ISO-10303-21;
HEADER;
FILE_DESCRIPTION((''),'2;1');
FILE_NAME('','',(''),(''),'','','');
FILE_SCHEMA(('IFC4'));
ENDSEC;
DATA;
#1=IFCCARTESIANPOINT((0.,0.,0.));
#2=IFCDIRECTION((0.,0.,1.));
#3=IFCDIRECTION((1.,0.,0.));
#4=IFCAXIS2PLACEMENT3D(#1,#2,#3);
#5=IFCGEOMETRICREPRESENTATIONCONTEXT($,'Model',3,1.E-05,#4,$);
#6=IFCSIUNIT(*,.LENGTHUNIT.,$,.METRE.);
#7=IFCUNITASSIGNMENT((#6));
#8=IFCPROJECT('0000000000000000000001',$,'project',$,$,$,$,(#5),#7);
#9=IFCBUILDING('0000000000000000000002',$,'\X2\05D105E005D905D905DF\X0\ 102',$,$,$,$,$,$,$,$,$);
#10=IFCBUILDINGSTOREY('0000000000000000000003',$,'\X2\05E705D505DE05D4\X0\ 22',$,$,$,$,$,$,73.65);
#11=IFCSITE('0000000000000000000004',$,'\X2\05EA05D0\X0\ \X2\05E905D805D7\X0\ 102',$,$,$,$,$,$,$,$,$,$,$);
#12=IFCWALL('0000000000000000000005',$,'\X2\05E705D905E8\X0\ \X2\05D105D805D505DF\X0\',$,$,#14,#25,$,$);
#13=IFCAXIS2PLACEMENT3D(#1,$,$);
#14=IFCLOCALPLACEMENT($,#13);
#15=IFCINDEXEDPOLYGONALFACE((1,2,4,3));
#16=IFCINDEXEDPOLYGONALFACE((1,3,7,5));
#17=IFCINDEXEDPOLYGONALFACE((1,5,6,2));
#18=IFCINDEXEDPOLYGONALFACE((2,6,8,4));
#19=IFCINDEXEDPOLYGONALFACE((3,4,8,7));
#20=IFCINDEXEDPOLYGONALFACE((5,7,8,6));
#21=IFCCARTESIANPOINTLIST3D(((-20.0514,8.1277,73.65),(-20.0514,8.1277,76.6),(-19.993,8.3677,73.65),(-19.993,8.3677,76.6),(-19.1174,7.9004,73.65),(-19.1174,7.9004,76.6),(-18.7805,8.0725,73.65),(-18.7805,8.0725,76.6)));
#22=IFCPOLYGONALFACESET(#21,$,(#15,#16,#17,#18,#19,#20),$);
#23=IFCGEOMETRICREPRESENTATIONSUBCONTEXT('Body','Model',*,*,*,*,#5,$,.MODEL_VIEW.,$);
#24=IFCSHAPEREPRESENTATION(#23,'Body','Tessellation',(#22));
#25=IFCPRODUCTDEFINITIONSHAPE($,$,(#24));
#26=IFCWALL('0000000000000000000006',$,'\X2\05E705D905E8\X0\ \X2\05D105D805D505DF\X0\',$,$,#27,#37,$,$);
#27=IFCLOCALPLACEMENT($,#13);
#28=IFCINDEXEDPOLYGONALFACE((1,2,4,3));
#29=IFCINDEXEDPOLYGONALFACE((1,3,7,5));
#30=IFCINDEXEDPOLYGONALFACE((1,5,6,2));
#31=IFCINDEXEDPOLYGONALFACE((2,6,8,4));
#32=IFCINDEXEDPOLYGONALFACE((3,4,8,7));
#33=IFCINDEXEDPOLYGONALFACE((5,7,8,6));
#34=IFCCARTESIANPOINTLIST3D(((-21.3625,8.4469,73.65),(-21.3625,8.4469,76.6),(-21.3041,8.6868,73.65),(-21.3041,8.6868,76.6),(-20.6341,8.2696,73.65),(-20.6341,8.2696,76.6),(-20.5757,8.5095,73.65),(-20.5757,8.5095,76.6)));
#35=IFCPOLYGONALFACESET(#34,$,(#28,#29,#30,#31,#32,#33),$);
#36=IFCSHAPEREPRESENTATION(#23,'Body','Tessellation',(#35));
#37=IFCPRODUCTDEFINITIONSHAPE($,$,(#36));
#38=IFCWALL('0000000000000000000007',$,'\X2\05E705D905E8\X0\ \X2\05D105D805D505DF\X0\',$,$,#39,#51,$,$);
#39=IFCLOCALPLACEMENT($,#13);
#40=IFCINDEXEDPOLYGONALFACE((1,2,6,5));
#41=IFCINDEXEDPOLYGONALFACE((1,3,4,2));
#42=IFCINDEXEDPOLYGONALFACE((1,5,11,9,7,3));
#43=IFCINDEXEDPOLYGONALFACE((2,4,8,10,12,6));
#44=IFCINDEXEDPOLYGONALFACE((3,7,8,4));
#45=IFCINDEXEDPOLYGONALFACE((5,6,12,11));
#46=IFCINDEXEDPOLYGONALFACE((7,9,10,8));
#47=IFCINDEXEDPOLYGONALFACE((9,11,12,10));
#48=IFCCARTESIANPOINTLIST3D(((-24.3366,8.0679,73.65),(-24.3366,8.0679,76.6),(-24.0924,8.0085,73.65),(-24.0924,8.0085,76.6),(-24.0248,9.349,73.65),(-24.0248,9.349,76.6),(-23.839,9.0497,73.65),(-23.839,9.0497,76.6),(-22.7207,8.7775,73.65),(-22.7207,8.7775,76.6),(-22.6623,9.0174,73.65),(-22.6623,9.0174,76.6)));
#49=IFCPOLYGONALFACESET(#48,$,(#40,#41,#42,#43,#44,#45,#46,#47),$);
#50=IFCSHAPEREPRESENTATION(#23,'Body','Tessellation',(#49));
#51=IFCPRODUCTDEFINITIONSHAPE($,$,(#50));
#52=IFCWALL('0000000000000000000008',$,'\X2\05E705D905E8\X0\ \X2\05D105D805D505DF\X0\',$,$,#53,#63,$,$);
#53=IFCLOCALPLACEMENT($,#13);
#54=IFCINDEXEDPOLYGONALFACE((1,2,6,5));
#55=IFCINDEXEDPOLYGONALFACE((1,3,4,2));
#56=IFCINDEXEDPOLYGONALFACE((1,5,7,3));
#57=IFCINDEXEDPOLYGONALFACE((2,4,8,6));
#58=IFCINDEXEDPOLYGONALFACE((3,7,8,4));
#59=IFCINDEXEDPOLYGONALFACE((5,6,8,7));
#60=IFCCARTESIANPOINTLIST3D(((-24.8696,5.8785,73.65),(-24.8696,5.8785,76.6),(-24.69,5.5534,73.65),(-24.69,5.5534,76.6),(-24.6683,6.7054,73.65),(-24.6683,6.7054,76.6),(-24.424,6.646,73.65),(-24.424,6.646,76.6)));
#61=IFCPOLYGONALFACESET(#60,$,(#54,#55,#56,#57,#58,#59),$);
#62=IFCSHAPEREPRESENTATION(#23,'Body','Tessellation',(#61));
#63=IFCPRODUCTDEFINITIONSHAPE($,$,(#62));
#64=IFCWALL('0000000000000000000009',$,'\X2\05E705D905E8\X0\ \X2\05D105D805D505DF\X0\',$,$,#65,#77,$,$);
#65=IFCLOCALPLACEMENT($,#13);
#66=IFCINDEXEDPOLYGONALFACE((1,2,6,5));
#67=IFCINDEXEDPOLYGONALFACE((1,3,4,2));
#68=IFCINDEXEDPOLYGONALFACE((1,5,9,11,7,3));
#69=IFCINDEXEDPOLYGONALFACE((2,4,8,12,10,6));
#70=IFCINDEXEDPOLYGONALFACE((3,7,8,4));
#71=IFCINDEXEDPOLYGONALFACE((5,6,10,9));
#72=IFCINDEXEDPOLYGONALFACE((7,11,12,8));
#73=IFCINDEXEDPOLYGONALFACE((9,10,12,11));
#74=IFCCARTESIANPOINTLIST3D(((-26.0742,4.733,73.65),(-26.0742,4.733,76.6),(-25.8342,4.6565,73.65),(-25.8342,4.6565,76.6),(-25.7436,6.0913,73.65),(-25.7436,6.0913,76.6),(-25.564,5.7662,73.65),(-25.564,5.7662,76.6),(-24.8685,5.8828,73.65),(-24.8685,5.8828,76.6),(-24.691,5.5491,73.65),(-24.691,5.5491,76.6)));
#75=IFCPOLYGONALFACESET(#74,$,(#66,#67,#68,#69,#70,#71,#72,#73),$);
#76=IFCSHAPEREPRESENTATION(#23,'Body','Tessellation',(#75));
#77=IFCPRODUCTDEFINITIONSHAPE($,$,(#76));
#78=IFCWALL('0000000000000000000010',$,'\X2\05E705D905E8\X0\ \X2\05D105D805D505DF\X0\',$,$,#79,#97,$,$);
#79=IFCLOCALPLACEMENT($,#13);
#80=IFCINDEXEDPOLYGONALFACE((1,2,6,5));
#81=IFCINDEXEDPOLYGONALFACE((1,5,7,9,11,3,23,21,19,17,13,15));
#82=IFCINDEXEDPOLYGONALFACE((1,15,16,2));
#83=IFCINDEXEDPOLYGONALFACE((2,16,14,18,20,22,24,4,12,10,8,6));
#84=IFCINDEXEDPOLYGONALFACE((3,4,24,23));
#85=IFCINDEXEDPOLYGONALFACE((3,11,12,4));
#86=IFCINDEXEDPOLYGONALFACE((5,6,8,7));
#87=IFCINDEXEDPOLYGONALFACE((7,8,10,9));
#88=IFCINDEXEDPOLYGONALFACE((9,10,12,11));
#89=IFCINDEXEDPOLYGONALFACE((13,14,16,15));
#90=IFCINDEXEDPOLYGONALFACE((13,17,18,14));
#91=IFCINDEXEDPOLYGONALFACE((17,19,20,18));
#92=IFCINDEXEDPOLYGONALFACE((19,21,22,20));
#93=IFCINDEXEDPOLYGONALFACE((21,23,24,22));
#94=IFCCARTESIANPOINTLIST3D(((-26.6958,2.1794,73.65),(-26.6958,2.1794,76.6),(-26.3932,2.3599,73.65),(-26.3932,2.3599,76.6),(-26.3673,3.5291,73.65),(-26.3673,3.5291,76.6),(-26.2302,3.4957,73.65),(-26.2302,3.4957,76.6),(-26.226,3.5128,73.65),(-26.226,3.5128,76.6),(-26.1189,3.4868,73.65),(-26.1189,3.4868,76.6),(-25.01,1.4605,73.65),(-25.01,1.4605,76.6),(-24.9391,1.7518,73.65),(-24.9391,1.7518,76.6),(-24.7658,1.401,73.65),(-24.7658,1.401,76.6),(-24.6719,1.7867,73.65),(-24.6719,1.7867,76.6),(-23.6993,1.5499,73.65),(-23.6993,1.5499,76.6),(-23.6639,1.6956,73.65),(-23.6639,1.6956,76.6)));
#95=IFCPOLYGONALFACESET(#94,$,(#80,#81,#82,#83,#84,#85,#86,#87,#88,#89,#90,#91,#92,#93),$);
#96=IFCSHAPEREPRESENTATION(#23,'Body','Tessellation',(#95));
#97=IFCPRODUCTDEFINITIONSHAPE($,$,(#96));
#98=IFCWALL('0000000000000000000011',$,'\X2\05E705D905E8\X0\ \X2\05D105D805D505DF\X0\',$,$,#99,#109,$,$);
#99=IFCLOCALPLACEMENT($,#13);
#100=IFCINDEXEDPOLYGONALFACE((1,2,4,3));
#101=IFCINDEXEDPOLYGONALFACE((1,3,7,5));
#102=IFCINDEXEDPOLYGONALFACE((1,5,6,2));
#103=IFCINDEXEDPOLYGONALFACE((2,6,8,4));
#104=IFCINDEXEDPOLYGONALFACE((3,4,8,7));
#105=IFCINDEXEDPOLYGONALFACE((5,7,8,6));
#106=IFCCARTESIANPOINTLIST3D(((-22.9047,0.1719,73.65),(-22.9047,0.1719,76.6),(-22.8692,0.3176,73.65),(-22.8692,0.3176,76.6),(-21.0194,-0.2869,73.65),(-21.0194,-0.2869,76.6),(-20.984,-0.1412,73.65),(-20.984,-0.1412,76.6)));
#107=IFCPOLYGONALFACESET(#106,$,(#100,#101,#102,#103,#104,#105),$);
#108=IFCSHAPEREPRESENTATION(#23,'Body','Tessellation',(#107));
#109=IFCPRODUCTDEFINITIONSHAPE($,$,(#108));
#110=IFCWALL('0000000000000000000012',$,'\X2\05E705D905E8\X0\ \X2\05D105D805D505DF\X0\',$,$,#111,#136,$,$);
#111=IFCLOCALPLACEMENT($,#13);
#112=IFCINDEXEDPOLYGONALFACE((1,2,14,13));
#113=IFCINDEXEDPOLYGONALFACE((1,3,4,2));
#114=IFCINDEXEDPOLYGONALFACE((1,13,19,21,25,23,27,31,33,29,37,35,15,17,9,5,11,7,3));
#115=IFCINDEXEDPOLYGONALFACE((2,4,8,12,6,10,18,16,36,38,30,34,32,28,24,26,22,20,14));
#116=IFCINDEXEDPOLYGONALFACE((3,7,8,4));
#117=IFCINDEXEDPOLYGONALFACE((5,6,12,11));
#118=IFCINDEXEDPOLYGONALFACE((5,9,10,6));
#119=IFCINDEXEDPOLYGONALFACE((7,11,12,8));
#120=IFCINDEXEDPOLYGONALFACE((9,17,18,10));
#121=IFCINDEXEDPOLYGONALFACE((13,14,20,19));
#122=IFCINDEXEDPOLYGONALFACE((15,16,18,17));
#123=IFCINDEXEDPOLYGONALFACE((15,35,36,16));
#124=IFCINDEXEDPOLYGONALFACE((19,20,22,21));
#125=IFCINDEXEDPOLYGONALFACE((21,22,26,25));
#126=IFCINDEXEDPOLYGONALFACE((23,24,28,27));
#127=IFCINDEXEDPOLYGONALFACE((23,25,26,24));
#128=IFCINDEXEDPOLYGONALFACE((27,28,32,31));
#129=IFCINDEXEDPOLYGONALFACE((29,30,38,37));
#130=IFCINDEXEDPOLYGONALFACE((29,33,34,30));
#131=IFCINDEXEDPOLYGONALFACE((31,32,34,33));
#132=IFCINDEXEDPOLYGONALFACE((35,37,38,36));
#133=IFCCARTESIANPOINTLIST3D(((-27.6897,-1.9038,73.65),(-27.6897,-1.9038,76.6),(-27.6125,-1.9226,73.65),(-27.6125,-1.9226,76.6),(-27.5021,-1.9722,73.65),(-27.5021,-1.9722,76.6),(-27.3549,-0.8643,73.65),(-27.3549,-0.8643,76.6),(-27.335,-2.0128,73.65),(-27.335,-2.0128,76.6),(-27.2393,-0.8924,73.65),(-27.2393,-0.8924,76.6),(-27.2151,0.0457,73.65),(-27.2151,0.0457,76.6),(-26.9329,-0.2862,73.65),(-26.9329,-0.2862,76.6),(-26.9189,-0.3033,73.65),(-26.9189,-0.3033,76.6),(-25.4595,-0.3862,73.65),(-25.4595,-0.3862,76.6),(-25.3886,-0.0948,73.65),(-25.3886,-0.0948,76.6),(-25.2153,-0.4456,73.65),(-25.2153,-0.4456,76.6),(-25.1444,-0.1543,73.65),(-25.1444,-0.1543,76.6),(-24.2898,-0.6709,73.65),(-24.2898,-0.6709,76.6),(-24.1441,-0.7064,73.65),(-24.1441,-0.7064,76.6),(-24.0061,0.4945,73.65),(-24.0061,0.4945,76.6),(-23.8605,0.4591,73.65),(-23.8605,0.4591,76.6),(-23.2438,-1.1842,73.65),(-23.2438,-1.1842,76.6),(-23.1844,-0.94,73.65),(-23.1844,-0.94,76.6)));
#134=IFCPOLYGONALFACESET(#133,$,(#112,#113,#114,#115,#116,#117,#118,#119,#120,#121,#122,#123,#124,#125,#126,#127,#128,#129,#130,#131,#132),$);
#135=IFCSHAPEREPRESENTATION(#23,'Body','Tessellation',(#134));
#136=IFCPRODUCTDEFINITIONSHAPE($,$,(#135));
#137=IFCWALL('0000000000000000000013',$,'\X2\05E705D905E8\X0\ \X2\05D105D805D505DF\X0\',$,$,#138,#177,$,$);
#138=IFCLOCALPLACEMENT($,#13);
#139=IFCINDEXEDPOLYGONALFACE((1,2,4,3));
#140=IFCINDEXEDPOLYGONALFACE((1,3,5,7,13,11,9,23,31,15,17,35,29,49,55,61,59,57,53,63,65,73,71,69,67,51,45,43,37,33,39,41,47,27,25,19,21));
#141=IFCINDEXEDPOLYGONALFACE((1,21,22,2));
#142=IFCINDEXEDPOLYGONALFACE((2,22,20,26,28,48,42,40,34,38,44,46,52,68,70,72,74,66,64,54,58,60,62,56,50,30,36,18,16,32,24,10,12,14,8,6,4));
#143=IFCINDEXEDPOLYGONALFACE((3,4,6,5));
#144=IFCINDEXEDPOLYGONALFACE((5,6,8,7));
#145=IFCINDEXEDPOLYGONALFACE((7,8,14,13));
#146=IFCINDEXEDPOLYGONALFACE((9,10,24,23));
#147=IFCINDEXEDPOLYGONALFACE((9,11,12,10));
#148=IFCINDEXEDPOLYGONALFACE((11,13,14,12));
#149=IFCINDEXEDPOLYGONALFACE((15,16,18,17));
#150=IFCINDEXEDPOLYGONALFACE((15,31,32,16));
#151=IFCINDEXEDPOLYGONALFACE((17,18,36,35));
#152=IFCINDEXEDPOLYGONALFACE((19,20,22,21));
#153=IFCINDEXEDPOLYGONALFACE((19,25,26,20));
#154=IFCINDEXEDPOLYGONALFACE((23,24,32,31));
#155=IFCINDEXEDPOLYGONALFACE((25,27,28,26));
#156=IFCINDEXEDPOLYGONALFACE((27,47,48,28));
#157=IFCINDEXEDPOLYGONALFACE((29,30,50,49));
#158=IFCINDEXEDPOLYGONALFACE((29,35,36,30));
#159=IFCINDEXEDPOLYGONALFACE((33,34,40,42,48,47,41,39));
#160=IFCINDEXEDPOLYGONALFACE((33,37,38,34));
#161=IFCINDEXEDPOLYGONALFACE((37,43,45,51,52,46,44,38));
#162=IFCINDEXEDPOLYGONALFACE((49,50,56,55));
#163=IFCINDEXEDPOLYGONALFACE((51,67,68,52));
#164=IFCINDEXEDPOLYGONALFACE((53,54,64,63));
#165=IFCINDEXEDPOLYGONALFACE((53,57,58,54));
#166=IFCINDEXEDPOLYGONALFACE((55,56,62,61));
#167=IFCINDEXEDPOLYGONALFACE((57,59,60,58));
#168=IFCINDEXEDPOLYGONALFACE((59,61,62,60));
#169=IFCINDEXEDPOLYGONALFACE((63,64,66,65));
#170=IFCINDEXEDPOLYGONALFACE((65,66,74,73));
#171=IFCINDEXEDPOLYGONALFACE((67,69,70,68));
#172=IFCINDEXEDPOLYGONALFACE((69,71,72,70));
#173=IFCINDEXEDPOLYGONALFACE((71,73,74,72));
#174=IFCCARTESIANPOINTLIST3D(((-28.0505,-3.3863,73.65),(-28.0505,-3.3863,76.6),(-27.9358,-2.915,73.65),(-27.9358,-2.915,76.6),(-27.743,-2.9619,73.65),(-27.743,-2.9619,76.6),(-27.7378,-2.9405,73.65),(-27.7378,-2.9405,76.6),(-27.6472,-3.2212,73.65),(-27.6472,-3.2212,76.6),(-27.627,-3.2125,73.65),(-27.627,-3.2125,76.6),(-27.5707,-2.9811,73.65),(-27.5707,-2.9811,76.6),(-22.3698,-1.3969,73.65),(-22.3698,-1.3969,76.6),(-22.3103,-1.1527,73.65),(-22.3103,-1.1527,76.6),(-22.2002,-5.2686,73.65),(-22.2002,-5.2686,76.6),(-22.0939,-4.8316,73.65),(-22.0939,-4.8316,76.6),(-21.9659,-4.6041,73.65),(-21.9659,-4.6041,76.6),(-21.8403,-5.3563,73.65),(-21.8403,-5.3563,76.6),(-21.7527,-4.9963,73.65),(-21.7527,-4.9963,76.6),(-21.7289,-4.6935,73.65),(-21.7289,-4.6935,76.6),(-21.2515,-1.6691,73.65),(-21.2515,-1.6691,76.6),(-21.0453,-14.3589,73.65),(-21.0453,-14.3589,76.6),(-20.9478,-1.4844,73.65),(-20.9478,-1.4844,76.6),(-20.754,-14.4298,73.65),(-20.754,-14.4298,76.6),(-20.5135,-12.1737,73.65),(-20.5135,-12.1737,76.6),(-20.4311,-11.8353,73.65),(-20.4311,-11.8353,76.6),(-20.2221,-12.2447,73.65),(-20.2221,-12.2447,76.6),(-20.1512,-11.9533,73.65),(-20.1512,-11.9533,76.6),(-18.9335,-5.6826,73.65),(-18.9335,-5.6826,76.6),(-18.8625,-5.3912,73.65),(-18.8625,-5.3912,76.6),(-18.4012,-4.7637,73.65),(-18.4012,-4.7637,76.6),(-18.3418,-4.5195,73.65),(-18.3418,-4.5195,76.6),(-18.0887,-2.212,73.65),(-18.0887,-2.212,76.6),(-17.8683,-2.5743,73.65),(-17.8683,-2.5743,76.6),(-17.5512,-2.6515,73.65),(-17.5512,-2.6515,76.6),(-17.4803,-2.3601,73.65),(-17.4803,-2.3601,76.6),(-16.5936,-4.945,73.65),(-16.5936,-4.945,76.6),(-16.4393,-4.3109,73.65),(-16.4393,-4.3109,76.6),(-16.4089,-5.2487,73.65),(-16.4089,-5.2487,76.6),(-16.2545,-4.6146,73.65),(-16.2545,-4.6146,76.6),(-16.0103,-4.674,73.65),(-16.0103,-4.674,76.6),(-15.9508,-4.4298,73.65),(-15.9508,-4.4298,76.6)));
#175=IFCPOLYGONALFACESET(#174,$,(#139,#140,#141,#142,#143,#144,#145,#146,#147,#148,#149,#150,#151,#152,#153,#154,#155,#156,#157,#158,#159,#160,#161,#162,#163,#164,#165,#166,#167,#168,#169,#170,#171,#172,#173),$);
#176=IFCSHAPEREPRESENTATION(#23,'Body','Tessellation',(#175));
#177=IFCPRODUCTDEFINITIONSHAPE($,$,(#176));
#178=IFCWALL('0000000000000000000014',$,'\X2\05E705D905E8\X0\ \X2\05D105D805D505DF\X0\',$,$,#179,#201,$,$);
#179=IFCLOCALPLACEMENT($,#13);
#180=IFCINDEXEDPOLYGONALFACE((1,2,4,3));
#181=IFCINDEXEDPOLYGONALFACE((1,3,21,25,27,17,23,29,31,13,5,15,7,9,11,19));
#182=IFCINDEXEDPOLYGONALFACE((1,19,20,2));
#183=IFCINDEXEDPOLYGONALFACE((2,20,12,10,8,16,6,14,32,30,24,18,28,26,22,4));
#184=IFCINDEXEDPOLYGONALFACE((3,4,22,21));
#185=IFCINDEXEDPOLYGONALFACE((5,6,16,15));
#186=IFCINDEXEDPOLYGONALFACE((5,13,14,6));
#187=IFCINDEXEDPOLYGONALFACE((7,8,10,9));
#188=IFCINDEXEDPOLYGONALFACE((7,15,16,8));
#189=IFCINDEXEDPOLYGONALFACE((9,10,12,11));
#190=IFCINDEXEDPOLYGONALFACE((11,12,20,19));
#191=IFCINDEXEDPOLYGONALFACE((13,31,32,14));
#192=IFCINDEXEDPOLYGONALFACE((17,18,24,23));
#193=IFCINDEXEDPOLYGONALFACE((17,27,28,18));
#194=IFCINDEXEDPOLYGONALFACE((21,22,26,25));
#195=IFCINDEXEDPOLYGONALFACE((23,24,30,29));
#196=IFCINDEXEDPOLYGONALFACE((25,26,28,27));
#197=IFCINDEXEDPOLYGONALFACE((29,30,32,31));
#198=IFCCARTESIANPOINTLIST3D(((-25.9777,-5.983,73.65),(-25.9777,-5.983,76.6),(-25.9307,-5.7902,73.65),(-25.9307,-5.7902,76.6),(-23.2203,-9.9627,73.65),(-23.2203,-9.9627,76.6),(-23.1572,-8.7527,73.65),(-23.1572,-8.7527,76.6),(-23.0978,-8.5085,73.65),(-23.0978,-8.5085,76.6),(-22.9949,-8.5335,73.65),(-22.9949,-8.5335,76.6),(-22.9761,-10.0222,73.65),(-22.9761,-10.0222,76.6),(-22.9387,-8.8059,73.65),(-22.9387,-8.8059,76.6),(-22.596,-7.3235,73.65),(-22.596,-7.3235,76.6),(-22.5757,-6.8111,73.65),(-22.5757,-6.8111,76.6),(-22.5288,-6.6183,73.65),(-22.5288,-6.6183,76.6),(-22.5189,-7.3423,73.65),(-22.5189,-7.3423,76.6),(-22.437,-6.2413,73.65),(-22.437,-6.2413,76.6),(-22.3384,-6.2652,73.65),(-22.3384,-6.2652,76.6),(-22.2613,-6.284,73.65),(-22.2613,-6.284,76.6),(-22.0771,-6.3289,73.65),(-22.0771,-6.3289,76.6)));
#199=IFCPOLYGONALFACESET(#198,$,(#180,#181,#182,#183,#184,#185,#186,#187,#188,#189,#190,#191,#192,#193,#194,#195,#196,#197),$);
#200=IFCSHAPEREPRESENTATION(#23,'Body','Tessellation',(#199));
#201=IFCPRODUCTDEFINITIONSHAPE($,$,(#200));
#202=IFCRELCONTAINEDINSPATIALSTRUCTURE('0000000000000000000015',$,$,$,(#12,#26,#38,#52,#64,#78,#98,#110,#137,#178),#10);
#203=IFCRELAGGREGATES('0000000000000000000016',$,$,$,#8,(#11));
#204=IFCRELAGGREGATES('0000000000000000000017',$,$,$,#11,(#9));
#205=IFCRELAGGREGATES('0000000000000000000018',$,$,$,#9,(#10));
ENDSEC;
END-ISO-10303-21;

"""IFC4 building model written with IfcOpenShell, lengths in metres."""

from ifc_helpers import new_model, si_unit, frame, origin_with_axes, context, subcontext, project, spatial, polyline, outline, extrude, element, save


model = new_model("IFC4")

# Units and contexts
model_context = context("Model", 3, precision=1e-05, world=origin_with_axes())
body_context = subcontext(model_context, "Body", "Model", "MODEL_VIEW")
ifc_project = project(units=[si_unit("LENGTHUNIT", "METRE")], contexts=[model_context])

# Site, building, storey
site = spatial("IfcSite", under=ifc_project, Name="תא שטח 102")
building = spatial("IfcBuilding", under=site, Name="בניין 102")
storey = spatial("IfcBuildingStorey", under=building, Name="קומה 22", Elevation=73.65)

# Walls
element("IfcWall", 1, inside=storey, Name="קיר בטון", context=body_context, shape_type="SweptSolid", body=[
    extrude(outline(polyline([(-19.1174, 7.9004), (-18.7805, 8.0725), (-19.993, 8.3677), (-20.0514, 8.1277), (-19.1174, 7.9004)])), frame((0.0, 0.0, 73.65)), (0.0, 0.0, 1.0), 2.95),
])
element("IfcWall", 2, inside=storey, Name="קיר בטון", context=body_context, shape_type="SweptSolid", body=[
    extrude(outline(polyline([(-20.5757, 8.5095), (-21.3041, 8.6868), (-21.3625, 8.4469), (-20.6341, 8.2696), (-20.5757, 8.5095)])), frame((0.0, 0.0, 73.65)), (0.0, 0.0, 1.0), 2.95),
])
element("IfcWall", 3, inside=storey, Name="קיר בטון", context=body_context, shape_type="SweptSolid", body=[
    extrude(outline(polyline([(-22.7207, 8.7775), (-22.6623, 9.0174), (-24.0248, 9.349), (-24.3366, 8.0679), (-24.0924, 8.0085), (-23.839, 9.0497), (-22.7207, 8.7775)])), frame((0.0, 0.0, 73.65)), (0.0, 0.0, 1.0), 2.95),
])
element("IfcWall", 4, inside=storey, Name="קיר בטון", context=body_context, shape_type="SweptSolid", body=[
    extrude(outline(polyline([(-24.8696, 5.8785), (-24.69, 5.5534), (-24.424, 6.646), (-24.6683, 6.7054), (-24.8696, 5.8785)])), frame((0.0, 0.0, 73.65)), (0.0, 0.0, 1.0), 2.95),
])
element("IfcWall", 5, inside=storey, Name="קיר בטון", context=body_context, shape_type="SweptSolid", body=[
    extrude(outline(polyline([(-26.0742, 4.733), (-25.8342, 4.6565), (-25.564, 5.7662), (-24.691, 5.5491), (-24.8685, 5.8828), (-25.7436, 6.0913), (-26.0742, 4.733)])), frame((0.0, 0.0, 73.65)), (0.0, 0.0, 1.0), 2.95),
])
element("IfcWall", 6, inside=storey, Name="קיר בטון", context=body_context, shape_type="SweptSolid", body=[
    extrude(outline(polyline([(-26.6958, 2.1794), (-24.9391, 1.7518), (-25.01, 1.4605), (-24.7658, 1.401), (-24.6719, 1.7867), (-23.6993, 1.5499), (-23.6639, 1.6956), (-26.3932, 2.3599), (-26.1189, 3.4868), (-26.226, 3.5128), (-26.2302, 3.4957), (-26.3673, 3.5291), (-26.6958, 2.1794)])), frame((0.0, 0.0, 73.65)), (0.0, 0.0, 1.0), 2.95),
])
element("IfcWall", 7, inside=storey, Name="קיר בטון", context=body_context, shape_type="SweptSolid", body=[
    extrude(outline(polyline([(-22.9047, 0.1719), (-21.0194, -0.2869), (-20.984, -0.1412), (-22.8692, 0.3176), (-22.9047, 0.1719)])), frame((0.0, 0.0, 73.65)), (0.0, 0.0, 1.0), 2.95),
])
element("IfcWall", 8, inside=storey, Name="קיר בטון", context=body_context, shape_type="SweptSolid", body=[
    extrude(outline(polyline([(-25.4595, -0.3862), (-27.2151, 0.0457), (-27.6897, -1.9038), (-27.6125, -1.9226), (-27.3549, -0.8643), (-27.2393, -0.8924), (-27.5021, -1.9722), (-27.335, -2.0128), (-26.9189, -0.3033), (-26.9329, -0.2862), (-23.2438, -1.1842), (-23.1844, -0.94), (-24.1441, -0.7064), (-23.8605, 0.4591), (-24.0061, 0.4945), (-24.2898, -0.6709), (-25.2153, -0.4456), (-25.1444, -0.1543), (-25.3886, -0.0948), (-25.4595, -0.3862)])), frame((0.0, 0.0, 73.65)), (0.0, 0.0, 1.0), 2.95),
])
element("IfcWall", 9, inside=storey, Name="קיר בטון", context=body_context, shape_type="SweptSolid", body=[
    extrude(outline(polyline([(-21.9659, -4.6041), (-27.6472, -3.2212), (-27.627, -3.2125), (-27.5707, -2.9811), (-27.7378, -2.9405), (-27.743, -2.9619), (-27.9358, -2.915), (-28.0505, -3.3863), (-22.0939, -4.8316), (-22.2002, -5.2686), (-21.8403, -5.3563), (-21.7527, -4.9963), (-18.9335, -5.6826), (-20.4311, -11.8353), (-20.5135, -12.1737), (-21.0453, -14.3589), (-20.754, -14.4298), (-20.2221, -12.2447), (-20.1512, -11.9533), (-18.4012, -4.7637), (-16.4089, -5.2487), (-16.2545, -4.6146), (-16.0103, -4.674), (-15.9508, -4.4298), (-16.4393, -4.3109), (-16.5936, -4.945), (-18.3418, -4.5195), (-17.8683, -2.5743), (-17.5512, -2.6515), (-17.4803, -2.3601), (-18.0887, -2.212), (-18.8625, -5.3912), (-21.7289, -4.6935), (-20.9478, -1.4844), (-22.3103, -1.1527), (-22.3698, -1.3969), (-21.2515, -1.6691), (-21.9659, -4.6041)])), frame((0.0, 0.0, 73.65)), (0.0, 0.0, 1.0), 2.95),
])
element("IfcWall", 10, inside=storey, Name="קיר בטון", context=body_context, shape_type="SweptSolid", body=[
    extrude(outline(polyline([(-25.9777, -5.983), (-22.5757, -6.8111), (-22.9949, -8.5335), (-23.0978, -8.5085), (-23.1572, -8.7527), (-22.9387, -8.8059), (-23.2203, -9.9627), (-22.9761, -10.0222), (-22.0771, -6.3289), (-22.2613, -6.284), (-22.5189, -7.3423), (-22.596, -7.3235), (-22.3384, -6.2652), (-22.437, -6.2413), (-22.5288, -6.6183), (-25.9307, -5.7902), (-25.9777, -5.983)])), frame((0.0, 0.0, 73.65)), (0.0, 0.0, 1.0), 2.95),
])

save(model, "model.ifc")
